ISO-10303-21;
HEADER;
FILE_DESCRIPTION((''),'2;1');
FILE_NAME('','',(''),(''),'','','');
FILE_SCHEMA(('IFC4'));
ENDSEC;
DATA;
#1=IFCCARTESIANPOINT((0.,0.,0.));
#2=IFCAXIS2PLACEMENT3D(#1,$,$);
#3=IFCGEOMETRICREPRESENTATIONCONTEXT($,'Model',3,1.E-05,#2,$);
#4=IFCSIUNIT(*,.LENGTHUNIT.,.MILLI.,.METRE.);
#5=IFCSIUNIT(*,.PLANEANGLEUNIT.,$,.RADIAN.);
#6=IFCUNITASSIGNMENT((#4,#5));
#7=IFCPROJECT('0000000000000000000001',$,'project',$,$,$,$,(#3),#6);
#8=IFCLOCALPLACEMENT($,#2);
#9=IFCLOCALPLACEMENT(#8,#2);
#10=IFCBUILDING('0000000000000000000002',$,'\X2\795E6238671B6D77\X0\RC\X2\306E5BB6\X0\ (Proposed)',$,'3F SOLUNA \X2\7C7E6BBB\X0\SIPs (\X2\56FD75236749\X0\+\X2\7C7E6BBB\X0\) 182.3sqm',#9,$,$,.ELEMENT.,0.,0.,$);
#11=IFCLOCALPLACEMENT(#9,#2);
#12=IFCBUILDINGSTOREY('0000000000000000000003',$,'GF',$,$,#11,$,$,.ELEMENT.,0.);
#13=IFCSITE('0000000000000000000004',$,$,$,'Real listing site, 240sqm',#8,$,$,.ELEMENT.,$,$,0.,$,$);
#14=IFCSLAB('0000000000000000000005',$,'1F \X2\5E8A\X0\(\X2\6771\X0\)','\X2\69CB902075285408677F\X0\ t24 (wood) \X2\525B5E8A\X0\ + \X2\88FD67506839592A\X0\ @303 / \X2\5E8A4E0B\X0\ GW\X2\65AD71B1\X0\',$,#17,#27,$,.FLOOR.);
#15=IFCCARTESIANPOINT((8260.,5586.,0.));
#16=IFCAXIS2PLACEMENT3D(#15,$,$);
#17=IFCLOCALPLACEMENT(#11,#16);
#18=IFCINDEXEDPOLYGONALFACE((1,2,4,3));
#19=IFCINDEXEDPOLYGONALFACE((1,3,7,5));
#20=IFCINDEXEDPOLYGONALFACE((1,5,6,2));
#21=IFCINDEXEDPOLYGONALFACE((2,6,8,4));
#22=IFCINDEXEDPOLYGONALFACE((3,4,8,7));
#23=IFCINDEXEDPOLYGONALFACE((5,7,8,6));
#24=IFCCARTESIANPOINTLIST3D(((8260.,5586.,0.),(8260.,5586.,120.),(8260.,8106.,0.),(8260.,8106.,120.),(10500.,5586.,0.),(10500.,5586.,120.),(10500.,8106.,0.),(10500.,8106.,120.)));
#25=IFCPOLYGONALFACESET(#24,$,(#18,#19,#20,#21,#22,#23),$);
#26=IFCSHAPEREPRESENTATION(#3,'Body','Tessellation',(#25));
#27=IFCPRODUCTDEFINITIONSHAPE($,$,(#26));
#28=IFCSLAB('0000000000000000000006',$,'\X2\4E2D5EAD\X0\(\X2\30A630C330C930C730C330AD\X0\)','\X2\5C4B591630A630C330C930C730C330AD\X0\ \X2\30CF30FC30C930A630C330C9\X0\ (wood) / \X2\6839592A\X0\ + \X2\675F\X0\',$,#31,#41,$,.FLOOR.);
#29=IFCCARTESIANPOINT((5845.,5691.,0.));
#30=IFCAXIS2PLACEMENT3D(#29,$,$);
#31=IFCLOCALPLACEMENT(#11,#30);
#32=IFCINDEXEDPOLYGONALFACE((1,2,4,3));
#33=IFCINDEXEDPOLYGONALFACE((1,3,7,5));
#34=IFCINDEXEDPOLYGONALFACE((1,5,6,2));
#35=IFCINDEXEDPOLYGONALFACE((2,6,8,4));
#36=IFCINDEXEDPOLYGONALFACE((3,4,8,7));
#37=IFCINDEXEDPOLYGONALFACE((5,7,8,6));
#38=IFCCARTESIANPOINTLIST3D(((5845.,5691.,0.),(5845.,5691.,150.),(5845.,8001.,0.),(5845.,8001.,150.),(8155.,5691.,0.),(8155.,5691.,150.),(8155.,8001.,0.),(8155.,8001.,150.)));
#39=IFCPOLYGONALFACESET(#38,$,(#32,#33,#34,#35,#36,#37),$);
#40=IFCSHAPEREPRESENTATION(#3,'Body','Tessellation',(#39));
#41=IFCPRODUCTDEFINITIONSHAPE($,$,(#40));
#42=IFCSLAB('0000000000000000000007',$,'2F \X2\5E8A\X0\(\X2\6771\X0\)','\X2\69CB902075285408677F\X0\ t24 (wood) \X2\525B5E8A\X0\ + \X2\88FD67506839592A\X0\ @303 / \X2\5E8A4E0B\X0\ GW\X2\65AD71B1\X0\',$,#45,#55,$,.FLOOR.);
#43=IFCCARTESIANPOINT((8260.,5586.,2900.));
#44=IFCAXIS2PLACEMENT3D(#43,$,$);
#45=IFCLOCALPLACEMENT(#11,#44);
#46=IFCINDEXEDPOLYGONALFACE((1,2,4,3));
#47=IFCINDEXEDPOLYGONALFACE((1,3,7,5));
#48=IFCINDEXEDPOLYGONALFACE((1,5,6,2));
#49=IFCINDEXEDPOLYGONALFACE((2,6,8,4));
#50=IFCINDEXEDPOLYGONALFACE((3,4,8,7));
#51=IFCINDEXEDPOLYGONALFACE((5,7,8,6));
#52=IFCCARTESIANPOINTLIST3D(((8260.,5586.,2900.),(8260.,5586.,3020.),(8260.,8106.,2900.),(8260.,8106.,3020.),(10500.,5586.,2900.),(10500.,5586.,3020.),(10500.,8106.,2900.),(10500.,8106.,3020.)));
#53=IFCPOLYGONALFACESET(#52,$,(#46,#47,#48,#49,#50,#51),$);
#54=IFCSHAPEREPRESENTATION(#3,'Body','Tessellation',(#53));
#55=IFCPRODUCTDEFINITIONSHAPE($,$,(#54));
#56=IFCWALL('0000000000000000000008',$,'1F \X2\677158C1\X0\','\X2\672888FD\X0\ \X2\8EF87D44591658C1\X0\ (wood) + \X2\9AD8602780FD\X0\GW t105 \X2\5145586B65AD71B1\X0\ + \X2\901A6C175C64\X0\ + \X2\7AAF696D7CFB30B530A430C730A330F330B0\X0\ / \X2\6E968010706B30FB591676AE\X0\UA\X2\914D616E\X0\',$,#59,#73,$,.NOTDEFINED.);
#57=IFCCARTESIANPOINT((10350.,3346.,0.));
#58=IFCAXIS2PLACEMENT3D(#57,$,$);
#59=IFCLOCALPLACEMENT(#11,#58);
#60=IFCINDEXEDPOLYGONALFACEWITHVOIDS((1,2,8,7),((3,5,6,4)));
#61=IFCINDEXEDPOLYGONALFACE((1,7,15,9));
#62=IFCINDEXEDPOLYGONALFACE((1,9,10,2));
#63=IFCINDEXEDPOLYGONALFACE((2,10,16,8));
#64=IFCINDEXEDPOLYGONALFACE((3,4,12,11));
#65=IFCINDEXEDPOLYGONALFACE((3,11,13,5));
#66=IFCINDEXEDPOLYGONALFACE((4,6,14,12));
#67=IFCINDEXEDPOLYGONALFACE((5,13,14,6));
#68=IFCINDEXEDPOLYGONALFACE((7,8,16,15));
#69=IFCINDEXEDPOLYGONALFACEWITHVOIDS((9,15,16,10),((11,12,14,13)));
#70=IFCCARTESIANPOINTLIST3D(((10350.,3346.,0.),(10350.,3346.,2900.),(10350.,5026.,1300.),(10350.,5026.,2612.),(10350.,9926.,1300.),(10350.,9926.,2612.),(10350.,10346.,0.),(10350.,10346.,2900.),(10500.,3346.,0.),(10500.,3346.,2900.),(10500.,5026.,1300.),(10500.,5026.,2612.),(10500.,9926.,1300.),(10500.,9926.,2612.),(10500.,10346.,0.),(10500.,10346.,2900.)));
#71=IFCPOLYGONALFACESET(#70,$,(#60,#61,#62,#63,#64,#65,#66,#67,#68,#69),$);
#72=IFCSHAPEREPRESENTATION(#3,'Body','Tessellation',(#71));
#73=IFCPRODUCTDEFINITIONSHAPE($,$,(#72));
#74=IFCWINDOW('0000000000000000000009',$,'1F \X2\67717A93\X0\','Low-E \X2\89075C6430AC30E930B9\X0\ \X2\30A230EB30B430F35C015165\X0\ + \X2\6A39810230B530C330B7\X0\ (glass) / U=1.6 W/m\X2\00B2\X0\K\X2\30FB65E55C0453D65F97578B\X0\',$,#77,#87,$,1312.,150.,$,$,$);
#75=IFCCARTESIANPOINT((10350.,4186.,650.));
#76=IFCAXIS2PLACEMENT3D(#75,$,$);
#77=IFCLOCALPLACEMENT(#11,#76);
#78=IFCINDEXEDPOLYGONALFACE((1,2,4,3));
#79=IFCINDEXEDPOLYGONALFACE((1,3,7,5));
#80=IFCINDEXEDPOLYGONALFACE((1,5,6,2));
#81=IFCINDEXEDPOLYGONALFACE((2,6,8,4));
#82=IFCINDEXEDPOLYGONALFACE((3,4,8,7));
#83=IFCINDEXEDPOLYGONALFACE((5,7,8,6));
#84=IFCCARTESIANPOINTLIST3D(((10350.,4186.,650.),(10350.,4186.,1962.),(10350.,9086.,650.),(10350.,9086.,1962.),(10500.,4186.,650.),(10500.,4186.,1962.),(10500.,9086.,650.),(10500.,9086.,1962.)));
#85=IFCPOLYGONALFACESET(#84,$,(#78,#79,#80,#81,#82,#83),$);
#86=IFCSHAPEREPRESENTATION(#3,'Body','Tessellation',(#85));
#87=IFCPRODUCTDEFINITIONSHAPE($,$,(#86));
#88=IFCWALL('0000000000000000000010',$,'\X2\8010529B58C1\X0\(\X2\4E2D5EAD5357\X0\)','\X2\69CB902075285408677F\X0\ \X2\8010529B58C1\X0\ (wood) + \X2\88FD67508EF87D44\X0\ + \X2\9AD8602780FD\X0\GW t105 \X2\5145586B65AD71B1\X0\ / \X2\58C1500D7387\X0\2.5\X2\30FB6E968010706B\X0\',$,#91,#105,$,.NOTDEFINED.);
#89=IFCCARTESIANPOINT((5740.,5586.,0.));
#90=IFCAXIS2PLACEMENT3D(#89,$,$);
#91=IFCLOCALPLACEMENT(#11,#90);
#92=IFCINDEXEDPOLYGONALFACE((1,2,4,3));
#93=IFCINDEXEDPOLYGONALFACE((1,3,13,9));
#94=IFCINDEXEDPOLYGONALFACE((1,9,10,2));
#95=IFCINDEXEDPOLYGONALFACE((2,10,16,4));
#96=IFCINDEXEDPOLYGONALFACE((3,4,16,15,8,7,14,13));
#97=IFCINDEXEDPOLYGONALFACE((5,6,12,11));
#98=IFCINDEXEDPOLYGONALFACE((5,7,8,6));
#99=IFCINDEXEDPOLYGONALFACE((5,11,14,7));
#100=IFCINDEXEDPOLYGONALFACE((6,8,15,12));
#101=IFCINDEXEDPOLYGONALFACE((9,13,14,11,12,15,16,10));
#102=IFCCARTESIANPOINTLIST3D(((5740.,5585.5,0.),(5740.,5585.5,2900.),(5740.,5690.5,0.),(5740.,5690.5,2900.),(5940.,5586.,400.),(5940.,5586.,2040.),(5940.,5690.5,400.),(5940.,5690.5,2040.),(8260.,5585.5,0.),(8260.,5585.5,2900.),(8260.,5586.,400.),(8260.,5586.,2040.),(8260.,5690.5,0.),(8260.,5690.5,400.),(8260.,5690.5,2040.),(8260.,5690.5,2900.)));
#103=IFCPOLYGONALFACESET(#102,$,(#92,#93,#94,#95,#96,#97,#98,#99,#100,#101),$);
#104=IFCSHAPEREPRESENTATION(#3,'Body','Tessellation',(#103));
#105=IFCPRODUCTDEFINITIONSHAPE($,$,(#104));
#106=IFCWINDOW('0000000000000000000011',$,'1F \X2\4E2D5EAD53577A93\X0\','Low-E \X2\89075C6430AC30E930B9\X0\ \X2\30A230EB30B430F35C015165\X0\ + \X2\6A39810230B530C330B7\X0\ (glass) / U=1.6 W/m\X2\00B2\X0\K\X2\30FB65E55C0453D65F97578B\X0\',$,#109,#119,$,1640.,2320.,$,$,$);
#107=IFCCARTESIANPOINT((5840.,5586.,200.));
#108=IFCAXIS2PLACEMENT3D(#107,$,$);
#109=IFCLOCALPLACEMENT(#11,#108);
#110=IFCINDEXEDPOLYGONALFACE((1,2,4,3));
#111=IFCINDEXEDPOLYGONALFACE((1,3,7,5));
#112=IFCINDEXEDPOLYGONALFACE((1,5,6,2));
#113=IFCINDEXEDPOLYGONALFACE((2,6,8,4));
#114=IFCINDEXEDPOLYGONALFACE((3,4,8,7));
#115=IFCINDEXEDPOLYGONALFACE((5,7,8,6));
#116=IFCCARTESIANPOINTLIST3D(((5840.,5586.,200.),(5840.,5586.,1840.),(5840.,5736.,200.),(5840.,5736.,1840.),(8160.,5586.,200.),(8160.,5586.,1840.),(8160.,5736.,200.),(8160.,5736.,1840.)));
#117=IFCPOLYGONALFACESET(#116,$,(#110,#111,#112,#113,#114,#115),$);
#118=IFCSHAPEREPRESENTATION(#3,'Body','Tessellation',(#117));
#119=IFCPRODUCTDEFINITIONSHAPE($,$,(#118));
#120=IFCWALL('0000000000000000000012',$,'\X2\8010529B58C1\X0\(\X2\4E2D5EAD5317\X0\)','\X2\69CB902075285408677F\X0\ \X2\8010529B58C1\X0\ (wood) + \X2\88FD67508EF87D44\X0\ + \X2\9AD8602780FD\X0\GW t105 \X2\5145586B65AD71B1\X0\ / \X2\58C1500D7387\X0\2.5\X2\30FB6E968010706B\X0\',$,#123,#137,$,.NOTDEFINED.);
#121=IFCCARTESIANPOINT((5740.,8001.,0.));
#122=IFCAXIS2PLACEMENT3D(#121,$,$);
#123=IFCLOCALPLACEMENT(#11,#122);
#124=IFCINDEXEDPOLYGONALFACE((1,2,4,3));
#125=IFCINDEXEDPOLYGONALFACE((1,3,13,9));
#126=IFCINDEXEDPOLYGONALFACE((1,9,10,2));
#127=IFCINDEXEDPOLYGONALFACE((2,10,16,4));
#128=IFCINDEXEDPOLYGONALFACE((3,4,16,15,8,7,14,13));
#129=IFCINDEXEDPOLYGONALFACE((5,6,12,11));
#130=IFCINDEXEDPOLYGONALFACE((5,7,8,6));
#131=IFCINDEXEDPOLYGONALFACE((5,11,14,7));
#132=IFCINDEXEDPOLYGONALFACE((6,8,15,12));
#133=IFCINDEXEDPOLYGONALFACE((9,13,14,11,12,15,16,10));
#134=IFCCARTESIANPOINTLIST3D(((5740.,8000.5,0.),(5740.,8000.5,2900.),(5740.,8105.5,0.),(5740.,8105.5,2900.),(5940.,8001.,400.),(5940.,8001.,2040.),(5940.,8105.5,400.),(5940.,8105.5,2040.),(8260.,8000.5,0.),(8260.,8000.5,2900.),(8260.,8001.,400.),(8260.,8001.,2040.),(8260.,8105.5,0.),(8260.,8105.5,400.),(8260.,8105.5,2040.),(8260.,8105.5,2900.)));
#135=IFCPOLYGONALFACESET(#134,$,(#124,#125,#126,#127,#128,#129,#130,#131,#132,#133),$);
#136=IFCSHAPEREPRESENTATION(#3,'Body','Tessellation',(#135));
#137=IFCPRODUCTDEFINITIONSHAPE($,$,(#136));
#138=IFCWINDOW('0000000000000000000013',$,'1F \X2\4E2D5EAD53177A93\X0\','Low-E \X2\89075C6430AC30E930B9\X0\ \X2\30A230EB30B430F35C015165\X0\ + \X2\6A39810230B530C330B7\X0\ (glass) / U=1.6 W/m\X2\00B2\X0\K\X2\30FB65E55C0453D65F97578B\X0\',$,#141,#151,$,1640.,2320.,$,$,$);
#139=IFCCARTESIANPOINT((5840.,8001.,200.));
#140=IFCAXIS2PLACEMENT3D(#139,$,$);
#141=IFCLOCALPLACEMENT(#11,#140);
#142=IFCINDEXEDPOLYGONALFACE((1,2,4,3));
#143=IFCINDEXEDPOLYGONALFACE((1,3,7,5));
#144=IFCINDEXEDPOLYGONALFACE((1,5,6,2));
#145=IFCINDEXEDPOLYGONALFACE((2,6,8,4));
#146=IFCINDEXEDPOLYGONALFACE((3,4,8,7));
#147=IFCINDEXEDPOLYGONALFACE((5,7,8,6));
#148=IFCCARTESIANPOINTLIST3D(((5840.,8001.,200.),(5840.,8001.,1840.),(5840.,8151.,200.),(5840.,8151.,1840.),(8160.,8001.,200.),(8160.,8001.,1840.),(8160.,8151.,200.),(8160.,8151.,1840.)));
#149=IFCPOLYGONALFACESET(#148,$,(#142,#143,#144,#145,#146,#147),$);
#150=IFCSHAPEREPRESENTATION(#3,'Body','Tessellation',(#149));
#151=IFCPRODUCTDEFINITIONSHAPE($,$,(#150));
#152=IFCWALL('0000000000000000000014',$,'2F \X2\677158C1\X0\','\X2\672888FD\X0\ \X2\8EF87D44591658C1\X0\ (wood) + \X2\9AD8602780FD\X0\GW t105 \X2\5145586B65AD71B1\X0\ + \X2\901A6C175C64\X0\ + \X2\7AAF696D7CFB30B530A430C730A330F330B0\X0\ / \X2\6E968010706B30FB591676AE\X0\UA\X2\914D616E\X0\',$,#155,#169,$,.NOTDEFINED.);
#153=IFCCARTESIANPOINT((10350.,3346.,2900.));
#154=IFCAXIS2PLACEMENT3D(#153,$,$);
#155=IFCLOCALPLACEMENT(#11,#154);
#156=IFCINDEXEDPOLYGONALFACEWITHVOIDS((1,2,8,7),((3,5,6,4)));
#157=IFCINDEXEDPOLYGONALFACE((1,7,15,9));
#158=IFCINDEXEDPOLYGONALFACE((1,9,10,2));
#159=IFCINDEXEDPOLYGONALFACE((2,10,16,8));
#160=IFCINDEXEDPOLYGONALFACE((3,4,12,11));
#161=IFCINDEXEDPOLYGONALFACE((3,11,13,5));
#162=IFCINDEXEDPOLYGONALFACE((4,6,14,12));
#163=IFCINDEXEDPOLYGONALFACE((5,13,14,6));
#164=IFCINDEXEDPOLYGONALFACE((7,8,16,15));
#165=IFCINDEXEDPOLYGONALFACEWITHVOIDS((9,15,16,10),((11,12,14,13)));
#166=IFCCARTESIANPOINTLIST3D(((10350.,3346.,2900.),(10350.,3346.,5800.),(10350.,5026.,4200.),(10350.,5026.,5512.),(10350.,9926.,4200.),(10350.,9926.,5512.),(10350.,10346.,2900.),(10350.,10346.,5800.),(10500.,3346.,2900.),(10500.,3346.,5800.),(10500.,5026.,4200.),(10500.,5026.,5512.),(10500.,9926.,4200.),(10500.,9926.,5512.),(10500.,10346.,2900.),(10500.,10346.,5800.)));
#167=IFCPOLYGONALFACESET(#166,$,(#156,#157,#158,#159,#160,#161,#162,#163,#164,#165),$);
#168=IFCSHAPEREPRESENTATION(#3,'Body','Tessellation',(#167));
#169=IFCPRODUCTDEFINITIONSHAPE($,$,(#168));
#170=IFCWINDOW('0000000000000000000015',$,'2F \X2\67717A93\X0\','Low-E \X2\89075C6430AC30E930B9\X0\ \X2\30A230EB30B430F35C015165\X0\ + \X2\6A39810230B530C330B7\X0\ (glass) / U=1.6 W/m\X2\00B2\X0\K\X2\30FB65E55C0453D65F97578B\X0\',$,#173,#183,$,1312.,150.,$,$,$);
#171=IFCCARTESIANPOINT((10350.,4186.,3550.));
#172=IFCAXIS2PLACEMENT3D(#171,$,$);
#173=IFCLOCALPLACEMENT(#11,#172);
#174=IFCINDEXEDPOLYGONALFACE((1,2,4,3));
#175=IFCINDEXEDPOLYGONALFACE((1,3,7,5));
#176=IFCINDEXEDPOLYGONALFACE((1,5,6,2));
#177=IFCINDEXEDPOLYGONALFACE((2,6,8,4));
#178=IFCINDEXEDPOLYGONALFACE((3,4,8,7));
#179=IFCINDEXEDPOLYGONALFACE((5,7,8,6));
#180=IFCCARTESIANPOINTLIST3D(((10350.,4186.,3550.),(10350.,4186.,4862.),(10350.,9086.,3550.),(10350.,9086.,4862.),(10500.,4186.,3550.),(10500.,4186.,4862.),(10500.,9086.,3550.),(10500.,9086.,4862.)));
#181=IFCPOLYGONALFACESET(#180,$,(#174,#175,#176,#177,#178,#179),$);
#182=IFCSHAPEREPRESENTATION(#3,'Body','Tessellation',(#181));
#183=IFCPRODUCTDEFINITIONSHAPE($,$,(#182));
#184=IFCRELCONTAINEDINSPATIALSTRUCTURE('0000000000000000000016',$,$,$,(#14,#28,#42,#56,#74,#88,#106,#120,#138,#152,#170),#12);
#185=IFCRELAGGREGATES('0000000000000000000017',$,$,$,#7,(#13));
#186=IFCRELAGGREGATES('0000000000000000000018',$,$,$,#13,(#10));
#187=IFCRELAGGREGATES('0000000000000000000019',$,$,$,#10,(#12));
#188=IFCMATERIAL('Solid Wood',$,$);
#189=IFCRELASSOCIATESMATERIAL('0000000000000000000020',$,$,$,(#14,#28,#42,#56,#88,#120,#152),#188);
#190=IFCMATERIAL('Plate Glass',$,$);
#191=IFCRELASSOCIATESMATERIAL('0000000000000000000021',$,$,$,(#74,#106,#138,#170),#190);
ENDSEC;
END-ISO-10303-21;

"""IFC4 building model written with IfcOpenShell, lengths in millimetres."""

from ifc_helpers import new_model, si_unit, frame, frame_2d, origin, place, context, project, spatial, rectangle, extrude, material, element, fill, save


model = new_model("IFC4")

# Units and contexts
model_context = context("Model", 3, precision=1e-05, world=origin())
ifc_project = project(units=[si_unit("LENGTHUNIT", "METRE", prefix="MILLI"), si_unit("PLANEANGLEUNIT", "RADIAN")], contexts=[model_context])

# Site, building, storey
site_placement = place(None, origin())
site = spatial("IfcSite", under=ifc_project, at=site_placement, ObjectType="Real listing site, 240sqm", CompositionType="ELEMENT", RefElevation=0.0)
building_placement = place(site_placement, origin())
building = spatial("IfcBuilding", under=site, at=building_placement, Name="神戸望海RCの家 (Proposed)", ObjectType="3F SOLUNA 籾殻SIPs (国産杉+籾殻) 182.3sqm", CompositionType="ELEMENT", ElevationOfRefHeight=0.0, ElevationOfTerrain=0.0)
storey_placement = place(building_placement, origin())
storey = spatial("IfcBuildingStorey", under=building, at=storey_placement, Name="GF", CompositionType="ELEMENT", Elevation=0.0)

# Slabs
ifc_material_1 = material(Name="Solid Wood")
slab_1_placement = place(storey_placement, frame((8260.0, 5586.0, 0.0)))
element("IfcSlab", 1, at=slab_1_placement, inside=storey, material=ifc_material_1, Name="1F 床(東)", Description="構造用合板 t24 (wood) 剛床 + 製材根太 @303 / 床下 GW断熱", PredefinedType="FLOOR", context=model_context, shape_type="SweptSolid", body=[
    extrude(rectangle(XDim=2240.0, YDim=2520.0, at=frame_2d((1120.0, 1260.0))), frame((8260.0, 5586.0, 0.0)), (0.0, 0.0, 1.0), 120.0),
])
slab_2_placement = place(storey_placement, frame((5845.0, 5691.0, 0.0)))
element("IfcSlab", 2, at=slab_2_placement, inside=storey, material=ifc_material_1, Name="中庭(ウッドデッキ)", Description="屋外ウッドデッキ ハードウッド (wood) / 根太 + 束", PredefinedType="FLOOR", context=model_context, shape_type="SweptSolid", body=[
    extrude(rectangle(XDim=2310.0, YDim=2310.0, at=frame_2d((1155.0, 1155.0))), frame((5845.0, 5691.0, 0.0)), (0.0, 0.0, 1.0), 150.0),
])
slab_3_placement = place(storey_placement, frame((8260.0, 5586.0, 2900.0)))
element("IfcSlab", 3, at=slab_3_placement, inside=storey, material=ifc_material_1, Name="2F 床(東)", Description="構造用合板 t24 (wood) 剛床 + 製材根太 @303 / 床下 GW断熱", PredefinedType="FLOOR", context=model_context, shape_type="SweptSolid", body=[
    extrude(rectangle(XDim=2240.0, YDim=2520.0, at=frame_2d((1120.0, 1260.0))), frame((8260.0, 5586.0, 2900.0)), (0.0, 0.0, 1.0), 120.0),
])

# Walls, openings, windows
wall_1_placement = place(storey_placement, frame((10350.0, 3346.0, 0.0)))
wall_1 = element("IfcWall", 4, at=wall_1_placement, inside=storey, material=ifc_material_1, Name="1F 東壁", Description="木製 軸組外壁 (wood) + 高性能GW t105 充填断熱 + 通気層 + 窯業系サイディング / 準耐火・外皮UA配慮", PredefinedType="NOTDEFINED", context=model_context, shape_type="SweptSolid", body=[
    extrude(rectangle(XDim=150.0, YDim=7000.0, at=frame_2d((75.0, 3500.0))), frame((10350.0, 3346.0, 0.0)), (0.0, 0.0, 1.0), 2900.0),
])
opening_1_placement = place(storey_placement, frame((10350.0, 4186.0, 650.0)))
opening_1 = element("IfcOpeningElement", 5, at=opening_1_placement, cuts=wall_1, PredefinedType="NOTDEFINED", context=model_context, shape_type="SweptSolid", body=[
    extrude(rectangle(XDim=150.0, YDim=4900.0, at=frame_2d((75.0, 2450.0))), frame((10350.0, 4186.0, 650.0)), (0.0, 0.0, 1.0), 1312.0),
])
ifc_material_2 = material(Name="Plate Glass")
window_1_placement = place(storey_placement, frame((10350.0, 4186.0, 650.0)))
window_1 = element("IfcWindow", 6, at=window_1_placement, inside=storey, material=ifc_material_2, Name="1F 東窓", Description="Low-E 複層ガラス アルゴン封入 + 樹脂サッシ (glass) / U=1.6 W/m²K・日射取得型", OverallHeight=1312.0, OverallWidth=150.0, context=model_context, shape_type="SweptSolid", body=[
    extrude(rectangle(XDim=150.0, YDim=4900.0, at=frame_2d((75.0, 2450.0))), frame((10350.0, 4186.0, 650.0)), (0.0, 0.0, 1.0), 1312.0),
])
fill(opening_1, window_1)
wall_2_placement = place(storey_placement, frame((5740.0, 5586.0, 0.0)))
wall_2 = element("IfcWall", 7, at=wall_2_placement, inside=storey, material=ifc_material_1, Name="耐力壁(中庭南)", Description="構造用合板 耐力壁 (wood) + 製材軸組 + 高性能GW t105 充填断熱 / 壁倍率2.5・準耐火", PredefinedType="NOTDEFINED", context=model_context, shape_type="SweptSolid", body=[
    extrude(rectangle(XDim=2520.0, YDim=105.0, at=frame_2d((1260.0, 52.0))), frame((5740.0, 5586.0, 0.0)), (0.0, 0.0, 1.0), 2900.0),
])
opening_2_placement = place(storey_placement, frame((5840.0, 5586.0, 200.0)))
opening_2 = element("IfcOpeningElement", 8, at=opening_2_placement, cuts=wall_2, PredefinedType="NOTDEFINED", context=model_context, shape_type="SweptSolid", body=[
    extrude(rectangle(XDim=2320.0, YDim=150.0, at=frame_2d((1160.0, 75.0))), frame((5840.0, 5586.0, 200.0)), (0.0, 0.0, 1.0), 1640.0),
])
window_2_placement = place(storey_placement, frame((5840.0, 5586.0, 200.0)))
window_2 = element("IfcWindow", 9, at=window_2_placement, inside=storey, material=ifc_material_2, Name="1F 中庭南窓", Description="Low-E 複層ガラス アルゴン封入 + 樹脂サッシ (glass) / U=1.6 W/m²K・日射取得型", OverallHeight=1640.0, OverallWidth=2320.0, context=model_context, shape_type="SweptSolid", body=[
    extrude(rectangle(XDim=2320.0, YDim=150.0, at=frame_2d((1160.0, 75.0))), frame((5840.0, 5586.0, 200.0)), (0.0, 0.0, 1.0), 1640.0),
])
fill(opening_2, window_2)
wall_3_placement = place(storey_placement, frame((5740.0, 8001.0, 0.0)))
wall_3 = element("IfcWall", 10, at=wall_3_placement, inside=storey, material=ifc_material_1, Name="耐力壁(中庭北)", Description="構造用合板 耐力壁 (wood) + 製材軸組 + 高性能GW t105 充填断熱 / 壁倍率2.5・準耐火", PredefinedType="NOTDEFINED", context=model_context, shape_type="SweptSolid", body=[
    extrude(rectangle(XDim=2520.0, YDim=105.0, at=frame_2d((1260.0, 52.0))), frame((5740.0, 8001.0, 0.0)), (0.0, 0.0, 1.0), 2900.0),
])
opening_3_placement = place(storey_placement, frame((5840.0, 8001.0, 200.0)))
opening_3 = element("IfcOpeningElement", 11, at=opening_3_placement, cuts=wall_3, PredefinedType="NOTDEFINED", context=model_context, shape_type="SweptSolid", body=[
    extrude(rectangle(XDim=2320.0, YDim=150.0, at=frame_2d((1160.0, 75.0))), frame((5840.0, 8001.0, 200.0)), (0.0, 0.0, 1.0), 1640.0),
])
window_3_placement = place(storey_placement, frame((5840.0, 8001.0, 200.0)))
window_3 = element("IfcWindow", 12, at=window_3_placement, inside=storey, material=ifc_material_2, Name="1F 中庭北窓", Description="Low-E 複層ガラス アルゴン封入 + 樹脂サッシ (glass) / U=1.6 W/m²K・日射取得型", OverallHeight=1640.0, OverallWidth=2320.0, context=model_context, shape_type="SweptSolid", body=[
    extrude(rectangle(XDim=2320.0, YDim=150.0, at=frame_2d((1160.0, 75.0))), frame((5840.0, 8001.0, 200.0)), (0.0, 0.0, 1.0), 1640.0),
])
fill(opening_3, window_3)

# Wall, opening, window
wall_4_placement = place(storey_placement, frame((10350.0, 3346.0, 2900.0)))
wall_4 = element("IfcWall", 13, at=wall_4_placement, inside=storey, material=ifc_material_1, Name="2F 東壁", Description="木製 軸組外壁 (wood) + 高性能GW t105 充填断熱 + 通気層 + 窯業系サイディング / 準耐火・外皮UA配慮", PredefinedType="NOTDEFINED", context=model_context, shape_type="SweptSolid", body=[
    extrude(rectangle(XDim=150.0, YDim=7000.0, at=frame_2d((75.0, 3500.0))), frame((10350.0, 3346.0, 2900.0)), (0.0, 0.0, 1.0), 2900.0),
])
opening_4_placement = place(storey_placement, frame((10350.0, 4186.0, 3550.0)))
opening_4 = element("IfcOpeningElement", 14, at=opening_4_placement, cuts=wall_4, PredefinedType="NOTDEFINED", context=model_context, shape_type="SweptSolid", body=[
    extrude(rectangle(XDim=150.0, YDim=4900.0, at=frame_2d((75.0, 2450.0))), frame((10350.0, 4186.0, 3550.0)), (0.0, 0.0, 1.0), 1312.0),
])
window_4_placement = place(storey_placement, frame((10350.0, 4186.0, 3550.0)))
window_4 = element("IfcWindow", 15, at=window_4_placement, inside=storey, material=ifc_material_2, Name="2F 東窓", Description="Low-E 複層ガラス アルゴン封入 + 樹脂サッシ (glass) / U=1.6 W/m²K・日射取得型", OverallHeight=1312.0, OverallWidth=150.0, context=model_context, shape_type="SweptSolid", body=[
    extrude(rectangle(XDim=150.0, YDim=4900.0, at=frame_2d((75.0, 2450.0))), frame((10350.0, 4186.0, 3550.0)), (0.0, 0.0, 1.0), 1312.0),
])
fill(opening_4, window_4)

save(model, "model.ifc")
